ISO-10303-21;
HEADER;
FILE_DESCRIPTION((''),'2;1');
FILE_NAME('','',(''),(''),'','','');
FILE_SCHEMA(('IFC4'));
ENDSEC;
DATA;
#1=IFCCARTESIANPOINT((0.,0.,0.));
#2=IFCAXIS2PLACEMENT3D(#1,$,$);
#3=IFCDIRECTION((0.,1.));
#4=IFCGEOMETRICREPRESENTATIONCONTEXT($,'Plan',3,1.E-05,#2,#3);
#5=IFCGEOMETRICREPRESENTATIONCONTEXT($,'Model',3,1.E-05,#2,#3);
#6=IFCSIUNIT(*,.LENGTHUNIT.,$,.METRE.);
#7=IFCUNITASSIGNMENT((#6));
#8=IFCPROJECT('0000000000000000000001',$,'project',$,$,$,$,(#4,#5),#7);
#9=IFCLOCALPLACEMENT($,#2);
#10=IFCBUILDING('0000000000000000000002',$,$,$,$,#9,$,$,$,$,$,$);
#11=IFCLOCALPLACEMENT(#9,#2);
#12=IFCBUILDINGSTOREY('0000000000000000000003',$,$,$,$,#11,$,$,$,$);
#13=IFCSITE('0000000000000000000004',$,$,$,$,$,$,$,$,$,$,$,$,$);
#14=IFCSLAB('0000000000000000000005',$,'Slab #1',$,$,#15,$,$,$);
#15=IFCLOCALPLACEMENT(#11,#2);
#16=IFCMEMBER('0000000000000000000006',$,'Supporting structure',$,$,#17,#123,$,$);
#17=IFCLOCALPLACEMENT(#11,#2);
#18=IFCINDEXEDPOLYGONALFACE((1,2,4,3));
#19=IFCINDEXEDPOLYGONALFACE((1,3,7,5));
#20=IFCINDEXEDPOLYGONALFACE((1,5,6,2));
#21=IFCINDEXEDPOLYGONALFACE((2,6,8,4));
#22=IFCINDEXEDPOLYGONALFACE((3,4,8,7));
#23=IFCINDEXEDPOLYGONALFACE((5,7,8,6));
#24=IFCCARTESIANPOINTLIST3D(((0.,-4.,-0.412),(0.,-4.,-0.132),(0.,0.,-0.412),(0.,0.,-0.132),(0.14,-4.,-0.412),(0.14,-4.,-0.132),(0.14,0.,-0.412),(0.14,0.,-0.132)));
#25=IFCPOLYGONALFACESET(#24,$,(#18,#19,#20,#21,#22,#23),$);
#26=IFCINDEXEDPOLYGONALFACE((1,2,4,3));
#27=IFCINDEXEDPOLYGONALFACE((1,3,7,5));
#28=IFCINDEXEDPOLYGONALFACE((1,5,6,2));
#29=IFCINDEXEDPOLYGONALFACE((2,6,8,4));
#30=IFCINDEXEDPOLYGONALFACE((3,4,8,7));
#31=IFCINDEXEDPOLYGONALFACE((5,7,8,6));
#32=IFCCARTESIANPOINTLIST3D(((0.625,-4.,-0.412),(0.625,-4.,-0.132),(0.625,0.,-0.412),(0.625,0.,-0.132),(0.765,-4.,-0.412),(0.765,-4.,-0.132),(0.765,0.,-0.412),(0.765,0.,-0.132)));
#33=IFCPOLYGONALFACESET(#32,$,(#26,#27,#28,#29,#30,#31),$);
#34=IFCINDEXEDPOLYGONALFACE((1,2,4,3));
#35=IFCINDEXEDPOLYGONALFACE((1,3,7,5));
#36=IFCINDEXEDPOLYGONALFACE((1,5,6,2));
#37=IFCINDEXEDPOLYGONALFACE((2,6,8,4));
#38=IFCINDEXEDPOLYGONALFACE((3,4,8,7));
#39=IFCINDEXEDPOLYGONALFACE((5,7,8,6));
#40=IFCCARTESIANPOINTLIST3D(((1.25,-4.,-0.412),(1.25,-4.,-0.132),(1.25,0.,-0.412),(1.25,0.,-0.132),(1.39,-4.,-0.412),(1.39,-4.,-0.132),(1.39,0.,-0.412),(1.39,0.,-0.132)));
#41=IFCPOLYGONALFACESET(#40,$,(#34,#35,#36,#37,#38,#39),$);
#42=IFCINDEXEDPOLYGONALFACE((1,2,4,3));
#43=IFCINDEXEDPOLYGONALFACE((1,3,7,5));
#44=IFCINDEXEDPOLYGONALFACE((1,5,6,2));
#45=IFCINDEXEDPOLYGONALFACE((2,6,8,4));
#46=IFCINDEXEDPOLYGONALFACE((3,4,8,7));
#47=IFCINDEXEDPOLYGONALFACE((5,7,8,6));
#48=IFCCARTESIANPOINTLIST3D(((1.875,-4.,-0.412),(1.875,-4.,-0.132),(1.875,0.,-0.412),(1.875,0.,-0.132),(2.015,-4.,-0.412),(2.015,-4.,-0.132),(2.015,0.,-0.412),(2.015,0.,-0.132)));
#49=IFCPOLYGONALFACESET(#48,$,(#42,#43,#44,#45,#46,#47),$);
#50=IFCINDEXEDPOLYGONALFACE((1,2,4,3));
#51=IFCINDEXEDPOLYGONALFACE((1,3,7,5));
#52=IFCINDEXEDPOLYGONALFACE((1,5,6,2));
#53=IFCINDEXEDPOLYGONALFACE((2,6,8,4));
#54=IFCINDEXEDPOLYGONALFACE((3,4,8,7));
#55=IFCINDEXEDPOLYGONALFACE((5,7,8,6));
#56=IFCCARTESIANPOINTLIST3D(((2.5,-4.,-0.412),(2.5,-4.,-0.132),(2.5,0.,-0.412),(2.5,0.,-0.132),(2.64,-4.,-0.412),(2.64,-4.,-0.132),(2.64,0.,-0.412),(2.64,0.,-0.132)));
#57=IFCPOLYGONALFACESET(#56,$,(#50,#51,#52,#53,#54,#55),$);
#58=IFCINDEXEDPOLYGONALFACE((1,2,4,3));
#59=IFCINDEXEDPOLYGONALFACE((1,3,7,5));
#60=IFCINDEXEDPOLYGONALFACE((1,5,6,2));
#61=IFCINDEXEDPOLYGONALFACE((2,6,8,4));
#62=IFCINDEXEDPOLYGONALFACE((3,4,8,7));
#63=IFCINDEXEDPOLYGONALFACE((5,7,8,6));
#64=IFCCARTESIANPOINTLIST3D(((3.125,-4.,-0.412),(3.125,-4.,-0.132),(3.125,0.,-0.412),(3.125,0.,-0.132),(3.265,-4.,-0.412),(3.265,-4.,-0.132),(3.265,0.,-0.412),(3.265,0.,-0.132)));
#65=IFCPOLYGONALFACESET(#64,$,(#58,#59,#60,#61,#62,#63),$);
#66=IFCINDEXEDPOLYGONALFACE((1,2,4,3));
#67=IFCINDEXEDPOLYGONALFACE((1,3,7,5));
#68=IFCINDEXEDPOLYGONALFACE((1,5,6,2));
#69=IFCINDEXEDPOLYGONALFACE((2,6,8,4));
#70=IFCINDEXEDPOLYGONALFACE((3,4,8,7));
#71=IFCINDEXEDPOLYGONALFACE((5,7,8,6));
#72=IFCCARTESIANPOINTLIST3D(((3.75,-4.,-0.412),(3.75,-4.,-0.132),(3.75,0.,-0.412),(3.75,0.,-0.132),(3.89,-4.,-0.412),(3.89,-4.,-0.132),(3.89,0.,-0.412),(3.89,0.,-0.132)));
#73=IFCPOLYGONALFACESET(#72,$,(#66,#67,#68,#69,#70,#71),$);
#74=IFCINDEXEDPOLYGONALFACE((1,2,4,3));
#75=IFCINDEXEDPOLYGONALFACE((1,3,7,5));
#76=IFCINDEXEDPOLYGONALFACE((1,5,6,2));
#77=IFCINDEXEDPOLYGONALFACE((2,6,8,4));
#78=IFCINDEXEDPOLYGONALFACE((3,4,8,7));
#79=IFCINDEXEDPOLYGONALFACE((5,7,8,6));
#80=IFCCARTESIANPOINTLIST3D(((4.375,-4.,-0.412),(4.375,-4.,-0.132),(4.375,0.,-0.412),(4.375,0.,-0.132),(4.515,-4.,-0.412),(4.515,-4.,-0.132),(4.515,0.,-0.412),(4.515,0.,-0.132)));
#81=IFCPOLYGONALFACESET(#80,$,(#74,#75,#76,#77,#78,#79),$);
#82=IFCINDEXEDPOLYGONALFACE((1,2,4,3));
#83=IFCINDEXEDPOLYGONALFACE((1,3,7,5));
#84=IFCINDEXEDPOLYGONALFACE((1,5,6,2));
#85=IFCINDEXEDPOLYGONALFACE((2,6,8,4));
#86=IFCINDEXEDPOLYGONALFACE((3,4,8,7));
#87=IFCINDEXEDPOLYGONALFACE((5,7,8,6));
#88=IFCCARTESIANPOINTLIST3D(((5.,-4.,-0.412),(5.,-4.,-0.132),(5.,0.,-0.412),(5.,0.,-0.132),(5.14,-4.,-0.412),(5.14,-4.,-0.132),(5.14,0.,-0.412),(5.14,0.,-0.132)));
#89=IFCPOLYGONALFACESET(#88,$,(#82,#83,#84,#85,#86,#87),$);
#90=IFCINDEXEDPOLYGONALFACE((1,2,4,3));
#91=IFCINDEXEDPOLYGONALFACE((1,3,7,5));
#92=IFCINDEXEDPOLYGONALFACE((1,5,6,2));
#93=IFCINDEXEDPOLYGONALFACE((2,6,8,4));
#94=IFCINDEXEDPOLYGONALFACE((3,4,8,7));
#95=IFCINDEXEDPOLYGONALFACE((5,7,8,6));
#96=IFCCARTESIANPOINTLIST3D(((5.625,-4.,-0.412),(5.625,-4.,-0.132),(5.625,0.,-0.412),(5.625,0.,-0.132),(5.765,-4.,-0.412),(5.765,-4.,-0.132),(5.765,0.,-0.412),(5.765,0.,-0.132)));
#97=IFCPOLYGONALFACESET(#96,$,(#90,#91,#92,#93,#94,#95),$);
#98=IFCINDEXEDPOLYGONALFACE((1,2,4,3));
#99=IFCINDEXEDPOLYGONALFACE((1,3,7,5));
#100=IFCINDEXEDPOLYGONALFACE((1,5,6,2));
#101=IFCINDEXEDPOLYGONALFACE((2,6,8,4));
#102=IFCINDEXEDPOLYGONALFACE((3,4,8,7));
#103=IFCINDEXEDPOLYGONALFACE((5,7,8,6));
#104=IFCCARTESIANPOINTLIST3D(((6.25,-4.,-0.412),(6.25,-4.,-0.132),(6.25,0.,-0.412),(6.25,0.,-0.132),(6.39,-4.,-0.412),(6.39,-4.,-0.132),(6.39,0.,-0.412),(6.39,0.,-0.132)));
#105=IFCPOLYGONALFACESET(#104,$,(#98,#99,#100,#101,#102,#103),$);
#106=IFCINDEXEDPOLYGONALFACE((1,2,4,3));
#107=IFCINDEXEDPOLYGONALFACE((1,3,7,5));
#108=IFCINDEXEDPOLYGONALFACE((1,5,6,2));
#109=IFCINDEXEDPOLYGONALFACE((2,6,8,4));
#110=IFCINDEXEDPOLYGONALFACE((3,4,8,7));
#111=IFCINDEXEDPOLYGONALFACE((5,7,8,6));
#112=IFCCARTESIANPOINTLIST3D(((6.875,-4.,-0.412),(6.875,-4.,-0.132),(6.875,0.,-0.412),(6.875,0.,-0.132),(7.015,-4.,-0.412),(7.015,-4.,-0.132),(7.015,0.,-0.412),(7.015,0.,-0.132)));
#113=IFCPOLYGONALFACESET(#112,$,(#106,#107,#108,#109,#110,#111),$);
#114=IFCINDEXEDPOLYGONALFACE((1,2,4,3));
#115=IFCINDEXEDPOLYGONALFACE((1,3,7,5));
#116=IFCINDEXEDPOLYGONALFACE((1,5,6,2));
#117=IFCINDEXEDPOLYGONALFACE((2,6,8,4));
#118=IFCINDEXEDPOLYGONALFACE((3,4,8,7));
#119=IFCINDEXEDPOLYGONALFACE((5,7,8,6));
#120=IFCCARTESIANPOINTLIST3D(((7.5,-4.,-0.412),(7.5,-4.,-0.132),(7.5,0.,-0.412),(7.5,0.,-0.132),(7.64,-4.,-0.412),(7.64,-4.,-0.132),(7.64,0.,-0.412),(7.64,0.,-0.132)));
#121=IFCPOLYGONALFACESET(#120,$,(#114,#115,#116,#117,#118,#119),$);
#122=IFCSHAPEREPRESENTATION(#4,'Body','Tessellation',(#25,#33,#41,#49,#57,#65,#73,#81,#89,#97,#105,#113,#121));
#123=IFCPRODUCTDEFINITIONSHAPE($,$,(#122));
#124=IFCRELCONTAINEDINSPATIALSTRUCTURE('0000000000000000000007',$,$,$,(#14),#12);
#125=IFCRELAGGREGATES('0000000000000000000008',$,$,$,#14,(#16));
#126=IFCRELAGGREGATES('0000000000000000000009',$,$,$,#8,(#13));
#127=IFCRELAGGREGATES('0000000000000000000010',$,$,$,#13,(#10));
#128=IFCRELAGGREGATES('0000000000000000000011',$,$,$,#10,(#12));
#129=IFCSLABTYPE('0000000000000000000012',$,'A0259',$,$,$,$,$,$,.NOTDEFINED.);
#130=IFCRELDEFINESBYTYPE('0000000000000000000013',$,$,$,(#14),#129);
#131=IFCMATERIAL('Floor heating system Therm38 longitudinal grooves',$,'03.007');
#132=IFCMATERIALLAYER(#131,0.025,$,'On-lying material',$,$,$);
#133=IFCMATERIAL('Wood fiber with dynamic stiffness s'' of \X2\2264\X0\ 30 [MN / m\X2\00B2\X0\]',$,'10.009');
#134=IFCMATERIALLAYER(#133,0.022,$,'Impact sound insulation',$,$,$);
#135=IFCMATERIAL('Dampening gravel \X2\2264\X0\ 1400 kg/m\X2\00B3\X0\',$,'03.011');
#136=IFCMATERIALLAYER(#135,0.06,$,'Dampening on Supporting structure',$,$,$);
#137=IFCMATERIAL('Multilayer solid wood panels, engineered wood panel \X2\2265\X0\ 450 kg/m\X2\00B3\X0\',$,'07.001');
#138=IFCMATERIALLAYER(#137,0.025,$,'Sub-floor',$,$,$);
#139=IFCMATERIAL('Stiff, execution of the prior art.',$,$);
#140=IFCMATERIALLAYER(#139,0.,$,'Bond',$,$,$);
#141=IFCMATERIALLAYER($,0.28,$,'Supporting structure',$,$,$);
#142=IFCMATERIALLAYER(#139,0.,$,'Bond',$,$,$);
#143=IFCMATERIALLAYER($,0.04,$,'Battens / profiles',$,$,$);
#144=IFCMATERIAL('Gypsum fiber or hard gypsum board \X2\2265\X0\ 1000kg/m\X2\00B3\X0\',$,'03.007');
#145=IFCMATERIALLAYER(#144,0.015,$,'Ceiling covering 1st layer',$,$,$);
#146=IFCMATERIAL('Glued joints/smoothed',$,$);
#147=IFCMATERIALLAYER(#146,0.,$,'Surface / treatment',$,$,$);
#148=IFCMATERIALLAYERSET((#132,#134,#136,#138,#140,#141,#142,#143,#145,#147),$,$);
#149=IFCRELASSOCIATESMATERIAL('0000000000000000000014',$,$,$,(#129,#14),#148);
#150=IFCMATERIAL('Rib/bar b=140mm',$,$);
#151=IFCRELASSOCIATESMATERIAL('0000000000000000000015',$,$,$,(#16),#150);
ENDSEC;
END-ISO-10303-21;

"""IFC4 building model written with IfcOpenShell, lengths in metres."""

from ifc_helpers import new_model, si_unit, direction, frame, frame_2d, origin, place, context, project, spatial, rectangle, extrude, material, layer, layer_set, type_object, element, aggregate, save


model = new_model("IFC4")

# Units and contexts
plan_context = context("Plan", 3, precision=1e-05, world=origin(), true_north=direction((0.0, 1.0)))
model_context = context("Model", 3, precision=1e-05, world=origin(), true_north=direction((0.0, 1.0)))
ifc_project = project(units=[si_unit("LENGTHUNIT", "METRE")], contexts=[plan_context, model_context])

# Site, building, storey
site = spatial("IfcSite", under=ifc_project)
building_placement = place(None, origin())
building = spatial("IfcBuilding", under=site, at=building_placement)
storey_placement = place(building_placement, origin())
storey = spatial("IfcBuildingStorey", under=building, at=storey_placement)

# Slab, member
ifc_material_1 = material(Name="Floor heating system Therm38 longitudinal grooves", Category="03.007")
ifc_layer_1 = layer(ifc_material_1, 0.025, Name="On-lying material")
ifc_material_2 = material(Name="Wood fiber with dynamic stiffness s' of ≤ 30 [MN / m²]", Category="10.009")
ifc_layer_2 = layer(ifc_material_2, 0.022, Name="Impact sound insulation")
ifc_material_3 = material(Name="Dampening gravel ≤ 1400 kg/m³", Category="03.011")
ifc_layer_3 = layer(ifc_material_3, 0.06, Name="Dampening on Supporting structure")
ifc_material_4 = material(Name="Multilayer solid wood panels, engineered wood panel ≥ 450 kg/m³", Category="07.001")
ifc_layer_4 = layer(ifc_material_4, 0.025, Name="Sub-floor")
ifc_material_5 = material(Name="Stiff, execution of the prior art.")
ifc_layer_5 = layer(ifc_material_5, 0.0, Name="Bond")
ifc_layer_6 = layer(None, 0.28, Name="Supporting structure")
ifc_layer_7 = layer(ifc_material_5, 0.0, Name="Bond")
ifc_layer_8 = layer(None, 0.04, Name="Battens / profiles")
ifc_material_6 = material(Name="Gypsum fiber or hard gypsum board ≥ 1000kg/m³", Category="03.007")
ifc_layer_9 = layer(ifc_material_6, 0.015, Name="Ceiling covering 1st layer")
ifc_material_7 = material(Name="Glued joints/smoothed")
ifc_layer_10 = layer(ifc_material_7, 0.0, Name="Surface / treatment")
ifc_layer_set = layer_set([ifc_layer_1, ifc_layer_2, ifc_layer_3, ifc_layer_4, ifc_layer_5, ifc_layer_6, ifc_layer_7, ifc_layer_8, ifc_layer_9, ifc_layer_10])
slab_type = type_object("IfcSlabType", Name="A0259", PredefinedType="NOTDEFINED", material=ifc_layer_set)
slab_placement = place(None, frame((0.0, 0.0, 0.0), z_axis=(0.0, 0.0, -1.0), x_axis=(1.0, 0.0, 0.0)))
slab = element("IfcSlab", 1, at=slab_placement, inside=storey, type_object=slab_type, material=ifc_layer_set, Name="Slab #1")
ifc_material_8 = material(Name="Rib/bar b=140mm")
member_1_placement = place(slab_placement, origin())
member_1 = element("IfcMember", 2, at=member_1_placement, material=ifc_material_8, Name="Supporting structure", context=plan_context, shape_type="SweptSolid", body=[
    extrude(rectangle(XDim=0.14, YDim=0.28, at=frame_2d((0.07, 0.14), x_axis=(1.0, 0.0))), frame((0.0, 4.0, 0.132), z_axis=(0.0, -1.0, 0.0), x_axis=(1.0, 0.0, 0.0)), (0.0, 0.0, 1.0), 4.0),
    extrude(rectangle(XDim=0.14, YDim=0.28, at=frame_2d((0.07, 0.14), x_axis=(1.0, 0.0))), frame((0.625, 4.0, 0.132), z_axis=(0.0, -1.0, 0.0), x_axis=(1.0, 0.0, 0.0)), (0.0, 0.0, 1.0), 4.0),
    extrude(rectangle(XDim=0.14, YDim=0.28, at=frame_2d((0.07, 0.14), x_axis=(1.0, 0.0))), frame((1.25, 4.0, 0.132), z_axis=(0.0, -1.0, 0.0), x_axis=(1.0, 0.0, 0.0)), (0.0, 0.0, 1.0), 4.0),
    extrude(rectangle(XDim=0.14, YDim=0.28, at=frame_2d((0.07, 0.14), x_axis=(1.0, 0.0))), frame((1.875, 4.0, 0.132), z_axis=(0.0, -1.0, 0.0), x_axis=(1.0, 0.0, 0.0)), (0.0, 0.0, 1.0), 4.0),
    extrude(rectangle(XDim=0.14, YDim=0.28, at=frame_2d((0.07, 0.14), x_axis=(1.0, 0.0))), frame((2.5, 4.0, 0.132), z_axis=(0.0, -1.0, 0.0), x_axis=(1.0, 0.0, 0.0)), (0.0, 0.0, 1.0), 4.0),
    extrude(rectangle(XDim=0.14, YDim=0.28, at=frame_2d((0.07, 0.14), x_axis=(1.0, 0.0))), frame((3.125, 4.0, 0.132), z_axis=(0.0, -1.0, 0.0), x_axis=(1.0, 0.0, 0.0)), (0.0, 0.0, 1.0), 4.0),
    extrude(rectangle(XDim=0.14, YDim=0.28, at=frame_2d((0.07, 0.14), x_axis=(1.0, 0.0))), frame((3.75, 4.0, 0.132), z_axis=(0.0, -1.0, 0.0), x_axis=(1.0, 0.0, 0.0)), (0.0, 0.0, 1.0), 4.0),
    extrude(rectangle(XDim=0.14, YDim=0.28, at=frame_2d((0.07, 0.14), x_axis=(1.0, 0.0))), frame((4.375, 4.0, 0.132), z_axis=(0.0, -1.0, 0.0), x_axis=(1.0, 0.0, 0.0)), (0.0, 0.0, 1.0), 4.0),
    extrude(rectangle(XDim=0.14, YDim=0.28, at=frame_2d((0.07, 0.14), x_axis=(1.0, 0.0))), frame((5.0, 4.0, 0.132), z_axis=(0.0, -1.0, 0.0), x_axis=(1.0, 0.0, 0.0)), (0.0, 0.0, 1.0), 4.0),
    extrude(rectangle(XDim=0.14, YDim=0.28, at=frame_2d((0.07, 0.14), x_axis=(1.0, 0.0))), frame((5.625, 4.0, 0.132), z_axis=(0.0, -1.0, 0.0), x_axis=(1.0, 0.0, 0.0)), (0.0, 0.0, 1.0), 4.0),
    extrude(rectangle(XDim=0.14, YDim=0.28, at=frame_2d((0.07, 0.14), x_axis=(1.0, 0.0))), frame((6.25, 4.0, 0.132), z_axis=(0.0, -1.0, 0.0), x_axis=(1.0, 0.0, 0.0)), (0.0, 0.0, 1.0), 4.0),
    extrude(rectangle(XDim=0.14, YDim=0.28, at=frame_2d((0.07, 0.14), x_axis=(1.0, 0.0))), frame((6.875, 4.0, 0.132), z_axis=(0.0, -1.0, 0.0), x_axis=(1.0, 0.0, 0.0)), (0.0, 0.0, 1.0), 4.0),
    extrude(rectangle(XDim=0.14, YDim=0.28, at=frame_2d((0.07, 0.14), x_axis=(1.0, 0.0))), frame((7.5, 4.0, 0.132), z_axis=(0.0, -1.0, 0.0), x_axis=(1.0, 0.0, 0.0)), (0.0, 0.0, 1.0), 4.0),
])
aggregate(slab, [member_1])

save(model, "model.ifc")
